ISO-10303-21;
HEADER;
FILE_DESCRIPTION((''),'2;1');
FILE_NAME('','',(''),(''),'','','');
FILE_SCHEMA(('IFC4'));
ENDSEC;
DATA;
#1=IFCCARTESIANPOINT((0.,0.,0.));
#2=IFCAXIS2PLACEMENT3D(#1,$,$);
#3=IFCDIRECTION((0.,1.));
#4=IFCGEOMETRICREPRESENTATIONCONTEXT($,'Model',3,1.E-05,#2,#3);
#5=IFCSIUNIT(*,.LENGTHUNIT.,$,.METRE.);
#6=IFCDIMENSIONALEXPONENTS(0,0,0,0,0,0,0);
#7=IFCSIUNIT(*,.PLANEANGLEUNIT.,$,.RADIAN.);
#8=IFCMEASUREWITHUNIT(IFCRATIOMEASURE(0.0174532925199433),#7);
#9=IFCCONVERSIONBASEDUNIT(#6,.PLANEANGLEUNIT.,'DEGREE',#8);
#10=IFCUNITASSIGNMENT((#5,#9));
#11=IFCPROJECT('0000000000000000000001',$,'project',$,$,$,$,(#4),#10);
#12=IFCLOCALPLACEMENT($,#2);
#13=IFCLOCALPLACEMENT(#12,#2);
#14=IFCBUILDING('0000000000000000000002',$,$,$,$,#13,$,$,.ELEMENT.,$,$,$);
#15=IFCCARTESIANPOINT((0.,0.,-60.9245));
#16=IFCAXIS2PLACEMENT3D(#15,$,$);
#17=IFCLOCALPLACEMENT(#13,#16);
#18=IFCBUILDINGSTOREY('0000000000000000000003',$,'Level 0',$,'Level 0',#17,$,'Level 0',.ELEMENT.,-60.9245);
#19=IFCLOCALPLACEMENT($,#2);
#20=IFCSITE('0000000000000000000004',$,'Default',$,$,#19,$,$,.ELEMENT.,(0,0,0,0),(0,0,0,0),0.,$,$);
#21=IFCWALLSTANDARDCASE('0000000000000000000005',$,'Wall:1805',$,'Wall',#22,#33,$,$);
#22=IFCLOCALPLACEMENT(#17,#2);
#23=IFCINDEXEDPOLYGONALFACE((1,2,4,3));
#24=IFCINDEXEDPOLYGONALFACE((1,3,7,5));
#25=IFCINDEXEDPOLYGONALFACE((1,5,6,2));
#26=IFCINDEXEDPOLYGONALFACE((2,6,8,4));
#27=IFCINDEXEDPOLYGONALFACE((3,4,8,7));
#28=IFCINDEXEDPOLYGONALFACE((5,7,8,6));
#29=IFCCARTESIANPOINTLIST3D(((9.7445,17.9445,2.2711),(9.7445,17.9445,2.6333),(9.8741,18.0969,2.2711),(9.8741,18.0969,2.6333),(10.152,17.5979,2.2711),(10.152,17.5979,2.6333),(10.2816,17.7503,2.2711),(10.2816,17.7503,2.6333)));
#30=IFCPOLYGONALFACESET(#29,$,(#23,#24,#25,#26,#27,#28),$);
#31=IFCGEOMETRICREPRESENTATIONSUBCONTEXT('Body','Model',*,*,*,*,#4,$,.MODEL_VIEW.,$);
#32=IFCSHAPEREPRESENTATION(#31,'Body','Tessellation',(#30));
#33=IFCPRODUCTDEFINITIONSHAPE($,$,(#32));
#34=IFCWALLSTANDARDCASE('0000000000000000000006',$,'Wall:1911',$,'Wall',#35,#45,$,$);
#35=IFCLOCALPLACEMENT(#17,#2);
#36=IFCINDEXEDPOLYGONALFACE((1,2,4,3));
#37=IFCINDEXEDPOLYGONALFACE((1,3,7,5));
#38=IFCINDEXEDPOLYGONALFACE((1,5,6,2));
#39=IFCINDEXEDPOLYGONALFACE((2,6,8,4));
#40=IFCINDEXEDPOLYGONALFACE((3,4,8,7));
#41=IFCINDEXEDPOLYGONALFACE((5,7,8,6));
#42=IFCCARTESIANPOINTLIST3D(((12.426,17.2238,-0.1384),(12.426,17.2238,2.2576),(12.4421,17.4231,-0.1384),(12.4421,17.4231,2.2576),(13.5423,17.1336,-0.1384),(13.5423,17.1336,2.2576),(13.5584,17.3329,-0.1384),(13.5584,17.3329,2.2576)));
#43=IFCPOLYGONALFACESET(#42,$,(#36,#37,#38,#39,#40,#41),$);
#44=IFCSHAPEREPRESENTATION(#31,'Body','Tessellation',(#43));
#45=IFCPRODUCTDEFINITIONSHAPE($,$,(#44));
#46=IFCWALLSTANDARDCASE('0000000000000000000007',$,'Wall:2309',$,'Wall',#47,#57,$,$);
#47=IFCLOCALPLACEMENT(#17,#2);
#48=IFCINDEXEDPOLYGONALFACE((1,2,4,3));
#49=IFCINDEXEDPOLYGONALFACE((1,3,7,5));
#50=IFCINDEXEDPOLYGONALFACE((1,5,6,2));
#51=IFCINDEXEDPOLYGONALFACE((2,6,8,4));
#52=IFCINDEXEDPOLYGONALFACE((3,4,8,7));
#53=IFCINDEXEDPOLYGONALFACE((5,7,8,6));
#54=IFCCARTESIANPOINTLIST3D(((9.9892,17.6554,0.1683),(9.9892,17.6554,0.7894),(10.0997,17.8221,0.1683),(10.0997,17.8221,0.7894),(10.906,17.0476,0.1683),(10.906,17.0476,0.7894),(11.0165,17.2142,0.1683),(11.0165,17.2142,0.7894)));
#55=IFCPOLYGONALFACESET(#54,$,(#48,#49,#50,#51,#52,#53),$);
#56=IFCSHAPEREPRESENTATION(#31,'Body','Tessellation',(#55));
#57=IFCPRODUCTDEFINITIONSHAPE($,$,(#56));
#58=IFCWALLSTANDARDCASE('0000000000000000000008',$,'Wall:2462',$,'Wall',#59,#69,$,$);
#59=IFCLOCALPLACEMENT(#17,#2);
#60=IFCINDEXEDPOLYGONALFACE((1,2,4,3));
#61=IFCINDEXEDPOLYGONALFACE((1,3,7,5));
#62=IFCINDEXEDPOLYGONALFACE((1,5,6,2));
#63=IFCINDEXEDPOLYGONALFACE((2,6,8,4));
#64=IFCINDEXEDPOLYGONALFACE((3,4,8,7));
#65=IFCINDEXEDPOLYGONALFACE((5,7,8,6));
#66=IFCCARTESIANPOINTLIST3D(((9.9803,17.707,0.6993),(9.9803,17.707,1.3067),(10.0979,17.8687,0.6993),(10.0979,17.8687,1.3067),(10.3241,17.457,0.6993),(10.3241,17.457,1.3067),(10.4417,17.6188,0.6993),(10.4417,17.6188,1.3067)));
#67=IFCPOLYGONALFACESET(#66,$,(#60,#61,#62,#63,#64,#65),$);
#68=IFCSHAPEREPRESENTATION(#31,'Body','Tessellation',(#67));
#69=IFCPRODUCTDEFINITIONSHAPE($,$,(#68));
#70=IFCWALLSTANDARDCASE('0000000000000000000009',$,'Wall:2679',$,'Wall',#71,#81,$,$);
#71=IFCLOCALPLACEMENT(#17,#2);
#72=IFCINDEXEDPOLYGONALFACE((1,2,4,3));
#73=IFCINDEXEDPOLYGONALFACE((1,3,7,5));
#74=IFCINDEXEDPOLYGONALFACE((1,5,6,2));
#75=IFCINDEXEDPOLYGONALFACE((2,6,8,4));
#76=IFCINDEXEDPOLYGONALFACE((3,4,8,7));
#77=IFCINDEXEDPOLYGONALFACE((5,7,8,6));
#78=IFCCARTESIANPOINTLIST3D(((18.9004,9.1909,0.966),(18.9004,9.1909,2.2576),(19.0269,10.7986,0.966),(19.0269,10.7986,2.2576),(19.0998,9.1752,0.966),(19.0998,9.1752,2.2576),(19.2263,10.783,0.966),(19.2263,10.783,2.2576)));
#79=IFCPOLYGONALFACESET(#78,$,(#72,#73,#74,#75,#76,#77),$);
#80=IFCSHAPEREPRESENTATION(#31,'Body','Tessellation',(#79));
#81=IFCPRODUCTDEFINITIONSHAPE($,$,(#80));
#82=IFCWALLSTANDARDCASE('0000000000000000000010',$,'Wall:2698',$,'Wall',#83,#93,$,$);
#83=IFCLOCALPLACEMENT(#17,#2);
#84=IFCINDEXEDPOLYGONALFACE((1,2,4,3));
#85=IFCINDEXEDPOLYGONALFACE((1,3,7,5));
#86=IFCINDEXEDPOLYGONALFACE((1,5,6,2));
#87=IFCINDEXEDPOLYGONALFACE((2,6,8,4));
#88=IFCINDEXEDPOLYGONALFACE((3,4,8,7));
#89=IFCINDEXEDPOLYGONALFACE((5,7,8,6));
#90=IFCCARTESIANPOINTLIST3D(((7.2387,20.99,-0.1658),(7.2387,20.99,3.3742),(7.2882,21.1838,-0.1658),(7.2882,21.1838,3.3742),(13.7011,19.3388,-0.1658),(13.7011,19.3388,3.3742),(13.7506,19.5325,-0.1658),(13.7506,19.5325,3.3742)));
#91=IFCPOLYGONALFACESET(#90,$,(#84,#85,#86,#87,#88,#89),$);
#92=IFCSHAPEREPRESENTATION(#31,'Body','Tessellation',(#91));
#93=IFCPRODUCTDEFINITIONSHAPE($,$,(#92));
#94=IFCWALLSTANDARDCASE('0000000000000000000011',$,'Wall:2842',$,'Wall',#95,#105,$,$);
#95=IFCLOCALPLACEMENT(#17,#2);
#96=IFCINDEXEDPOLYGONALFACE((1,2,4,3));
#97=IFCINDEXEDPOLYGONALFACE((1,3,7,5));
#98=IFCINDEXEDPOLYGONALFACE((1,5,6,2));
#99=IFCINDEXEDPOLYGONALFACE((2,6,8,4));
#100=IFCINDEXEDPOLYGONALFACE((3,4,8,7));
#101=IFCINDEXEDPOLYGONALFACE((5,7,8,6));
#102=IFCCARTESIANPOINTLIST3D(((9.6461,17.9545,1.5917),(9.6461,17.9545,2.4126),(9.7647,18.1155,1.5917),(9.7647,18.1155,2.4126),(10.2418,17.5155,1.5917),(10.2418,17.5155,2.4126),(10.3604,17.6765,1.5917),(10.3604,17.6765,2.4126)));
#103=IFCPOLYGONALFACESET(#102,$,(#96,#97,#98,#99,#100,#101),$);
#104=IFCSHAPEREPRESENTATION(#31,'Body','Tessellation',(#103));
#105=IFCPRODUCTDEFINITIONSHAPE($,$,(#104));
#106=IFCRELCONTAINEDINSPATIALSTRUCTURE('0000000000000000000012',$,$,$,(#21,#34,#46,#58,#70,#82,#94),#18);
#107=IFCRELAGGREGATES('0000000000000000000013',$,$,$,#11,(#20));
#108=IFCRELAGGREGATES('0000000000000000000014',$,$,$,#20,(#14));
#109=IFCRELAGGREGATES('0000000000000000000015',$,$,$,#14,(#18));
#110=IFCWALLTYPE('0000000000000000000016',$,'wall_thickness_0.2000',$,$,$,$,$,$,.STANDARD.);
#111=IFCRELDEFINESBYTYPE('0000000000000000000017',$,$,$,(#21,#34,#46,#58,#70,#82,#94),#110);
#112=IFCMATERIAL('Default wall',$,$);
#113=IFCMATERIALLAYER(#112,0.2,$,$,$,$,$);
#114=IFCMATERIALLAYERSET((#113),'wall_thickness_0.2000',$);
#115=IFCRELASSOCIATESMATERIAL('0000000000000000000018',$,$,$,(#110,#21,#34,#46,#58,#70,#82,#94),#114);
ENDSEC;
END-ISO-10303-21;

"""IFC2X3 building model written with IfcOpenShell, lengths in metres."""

from ifc_helpers import new_model, entity, si_unit, converted_unit, direction, frame, origin, place, context, subcontext, project, spatial, polyline, outline, extrude, material, layer, layer_set, layer_usage, type_object, element, save


model = new_model("IFC2X3")

# Units and contexts
model_context = context("Model", 3, precision=1e-05, world=origin(), true_north=direction((0.0, 1.0)))
body_context = subcontext(model_context, "Body", "Model", "MODEL_VIEW")
ifc_project = project(units=[si_unit("LENGTHUNIT", "METRE"), converted_unit("PLANEANGLEUNIT", "DEGREE", entity("IfcRatioMeasure", 0.0174532925199433), si_unit("PLANEANGLEUNIT", "RADIAN"), dimensions=[0, 0, 0, 0, 0, 0, 0])], contexts=[model_context])

# Site, building, storey
site_placement = place(None, origin())
site = spatial("IfcSite", under=ifc_project, at=site_placement, Name="Default", CompositionType="ELEMENT", RefLatitude=(0, 0, 0, 0), RefLongitude=(0, 0, 0, 0), RefElevation=0.0)
placement_1 = place(None, origin())
building_placement = place(placement_1, origin())
building = spatial("IfcBuilding", under=site, at=building_placement, CompositionType="ELEMENT")
storey_placement = place(building_placement, frame((0.0, 0.0, -60.9245)))
storey = spatial("IfcBuildingStorey", under=building, at=storey_placement, Name="Level 0", ObjectType="Level 0", LongName="Level 0", CompositionType="ELEMENT", Elevation=-60.9245)

# Walls
ifc_material = material(Name="Default wall")
ifc_layer = layer(ifc_material, 0.2)
ifc_layer_set = layer_set([ifc_layer], Name="wall_thickness_0.2000")
ifc_layer_usage = layer_usage(ifc_layer_set, "AXIS2", "POSITIVE", -0.1)
wall_type = type_object("IfcWallType", Name="wall_thickness_0.2000", PredefinedType="STANDARD", material=ifc_layer_set)
placement_2 = place(building_placement, frame((0.0, 0.0, -58.6534)))
wall_1_placement = place(placement_2, frame((9.8093, 18.0207, 0.0), z_axis=(0.0, 0.0, 1.0), x_axis=(0.761789, -0.647825, 0.0)))
element("IfcWallStandardCase", 1, at=wall_1_placement, inside=storey, type_object=wall_type, material=ifc_layer_usage, Name="Wall:1805", ObjectType="Wall", context=body_context, shape_type="SweptSolid", body=[
    extrude(outline(polyline([(0.535, -0.1), (0.535, 0.1), (0.0, 0.1), (0.0, -0.1), (0.535, -0.1)])), origin(), (0.0, 0.0, 1.0), 0.3621),
])
placement_3 = place(building_placement, frame((0.0, 0.0, -61.0629)))
wall_2_placement = place(placement_3, frame((12.434, 17.3234, 0.0), z_axis=(0.0, 0.0, 1.0), x_axis=(0.996753, -0.080516, 0.0)))
element("IfcWallStandardCase", 2, at=wall_2_placement, inside=storey, type_object=wall_type, material=ifc_layer_usage, Name="Wall:1911", ObjectType="Wall", context=body_context, shape_type="SweptSolid", body=[
    extrude(outline(polyline([(1.12, -0.1), (1.12, 0.1), (0.0, 0.1), (0.0, -0.1), (1.12, -0.1)])), origin(), (0.0, 0.0, 1.0), 2.396),
])
placement_4 = place(building_placement, frame((0.0, 0.0, -60.7562)))
wall_3_placement = place(placement_4, frame((10.0444, 17.7387, 0.0), z_axis=(0.0, 0.0, 1.0), x_axis=(0.833457, -0.552585, 0.0)))
element("IfcWallStandardCase", 3, at=wall_3_placement, inside=storey, type_object=wall_type, material=ifc_layer_usage, Name="Wall:2309", ObjectType="Wall", context=body_context, shape_type="SweptSolid", body=[
    extrude(outline(polyline([(1.1, -0.1), (1.1, 0.1), (0.0, 0.1), (0.0, -0.1), (1.1, -0.1)])), origin(), (0.0, 0.0, 1.0), 0.6211),
])
placement_5 = place(building_placement, frame((0.0, 0.0, -60.2252)))
wall_4_placement = place(placement_5, frame((10.3829, 17.5379, 0.0), z_axis=(0.0, 0.0, 1.0), x_axis=(-0.808794, 0.588093, 0.0)))
element("IfcWallStandardCase", 4, at=wall_4_placement, inside=storey, type_object=wall_type, material=ifc_layer_usage, Name="Wall:2462", ObjectType="Wall", context=body_context, shape_type="SweptSolid", body=[
    extrude(outline(polyline([(0.425, -0.1), (0.425, 0.1), (0.0, 0.1), (0.0, -0.1), (0.425, -0.1)])), origin(), (0.0, 0.0, 1.0), 0.6075),
])
placement_6 = place(building_placement, frame((0.0, 0.0, -59.9585)))
wall_5_placement = place(placement_6, frame((19.1266, 10.7908, 0.0), z_axis=(0.0, 0.0, 1.0), x_axis=(-0.078451, -0.996918, 0.0)))
element("IfcWallStandardCase", 5, at=wall_5_placement, inside=storey, type_object=wall_type, material=ifc_layer_usage, Name="Wall:2679", ObjectType="Wall", context=body_context, shape_type="SweptSolid", body=[
    extrude(outline(polyline([(1.6128, -0.1), (1.6128, 0.1), (0.0, 0.1), (0.0, -0.1), (1.6128, -0.1)])), origin(), (0.0, 0.0, 1.0), 1.2916),
])
placement_7 = place(building_placement, frame((0.0, 0.0, -61.0903)))
wall_6_placement = place(placement_7, frame((7.2634, 21.0869, 0.0), z_axis=(0.0, 0.0, 1.0), x_axis=(0.968873, -0.247559, 0.0)))
element("IfcWallStandardCase", 6, at=wall_6_placement, inside=storey, type_object=wall_type, material=ifc_layer_usage, Name="Wall:2698", ObjectType="Wall", context=body_context, shape_type="SweptSolid", body=[
    extrude(outline(polyline([(6.67, -0.1), (6.67, 0.1), (0.0, 0.1), (0.0, -0.1), (6.67, -0.1)])), origin(), (0.0, 0.0, 1.0), 3.54),
])
placement_8 = place(building_placement, frame((0.0, 0.0, -59.3328)))
wall_7_placement = place(placement_8, frame((9.7054, 18.035, 0.0), z_axis=(0.0, 0.0, 1.0), x_axis=(0.805011, -0.59326, 0.0)))
element("IfcWallStandardCase", 7, at=wall_7_placement, inside=storey, type_object=wall_type, material=ifc_layer_usage, Name="Wall:2842", ObjectType="Wall", context=body_context, shape_type="SweptSolid", body=[
    extrude(outline(polyline([(0.74, -0.1), (0.74, 0.1), (0.0, 0.1), (0.0, -0.1), (0.74, -0.1)])), origin(), (0.0, 0.0, 1.0), 0.8209),
])

save(model, "model.ifc")
